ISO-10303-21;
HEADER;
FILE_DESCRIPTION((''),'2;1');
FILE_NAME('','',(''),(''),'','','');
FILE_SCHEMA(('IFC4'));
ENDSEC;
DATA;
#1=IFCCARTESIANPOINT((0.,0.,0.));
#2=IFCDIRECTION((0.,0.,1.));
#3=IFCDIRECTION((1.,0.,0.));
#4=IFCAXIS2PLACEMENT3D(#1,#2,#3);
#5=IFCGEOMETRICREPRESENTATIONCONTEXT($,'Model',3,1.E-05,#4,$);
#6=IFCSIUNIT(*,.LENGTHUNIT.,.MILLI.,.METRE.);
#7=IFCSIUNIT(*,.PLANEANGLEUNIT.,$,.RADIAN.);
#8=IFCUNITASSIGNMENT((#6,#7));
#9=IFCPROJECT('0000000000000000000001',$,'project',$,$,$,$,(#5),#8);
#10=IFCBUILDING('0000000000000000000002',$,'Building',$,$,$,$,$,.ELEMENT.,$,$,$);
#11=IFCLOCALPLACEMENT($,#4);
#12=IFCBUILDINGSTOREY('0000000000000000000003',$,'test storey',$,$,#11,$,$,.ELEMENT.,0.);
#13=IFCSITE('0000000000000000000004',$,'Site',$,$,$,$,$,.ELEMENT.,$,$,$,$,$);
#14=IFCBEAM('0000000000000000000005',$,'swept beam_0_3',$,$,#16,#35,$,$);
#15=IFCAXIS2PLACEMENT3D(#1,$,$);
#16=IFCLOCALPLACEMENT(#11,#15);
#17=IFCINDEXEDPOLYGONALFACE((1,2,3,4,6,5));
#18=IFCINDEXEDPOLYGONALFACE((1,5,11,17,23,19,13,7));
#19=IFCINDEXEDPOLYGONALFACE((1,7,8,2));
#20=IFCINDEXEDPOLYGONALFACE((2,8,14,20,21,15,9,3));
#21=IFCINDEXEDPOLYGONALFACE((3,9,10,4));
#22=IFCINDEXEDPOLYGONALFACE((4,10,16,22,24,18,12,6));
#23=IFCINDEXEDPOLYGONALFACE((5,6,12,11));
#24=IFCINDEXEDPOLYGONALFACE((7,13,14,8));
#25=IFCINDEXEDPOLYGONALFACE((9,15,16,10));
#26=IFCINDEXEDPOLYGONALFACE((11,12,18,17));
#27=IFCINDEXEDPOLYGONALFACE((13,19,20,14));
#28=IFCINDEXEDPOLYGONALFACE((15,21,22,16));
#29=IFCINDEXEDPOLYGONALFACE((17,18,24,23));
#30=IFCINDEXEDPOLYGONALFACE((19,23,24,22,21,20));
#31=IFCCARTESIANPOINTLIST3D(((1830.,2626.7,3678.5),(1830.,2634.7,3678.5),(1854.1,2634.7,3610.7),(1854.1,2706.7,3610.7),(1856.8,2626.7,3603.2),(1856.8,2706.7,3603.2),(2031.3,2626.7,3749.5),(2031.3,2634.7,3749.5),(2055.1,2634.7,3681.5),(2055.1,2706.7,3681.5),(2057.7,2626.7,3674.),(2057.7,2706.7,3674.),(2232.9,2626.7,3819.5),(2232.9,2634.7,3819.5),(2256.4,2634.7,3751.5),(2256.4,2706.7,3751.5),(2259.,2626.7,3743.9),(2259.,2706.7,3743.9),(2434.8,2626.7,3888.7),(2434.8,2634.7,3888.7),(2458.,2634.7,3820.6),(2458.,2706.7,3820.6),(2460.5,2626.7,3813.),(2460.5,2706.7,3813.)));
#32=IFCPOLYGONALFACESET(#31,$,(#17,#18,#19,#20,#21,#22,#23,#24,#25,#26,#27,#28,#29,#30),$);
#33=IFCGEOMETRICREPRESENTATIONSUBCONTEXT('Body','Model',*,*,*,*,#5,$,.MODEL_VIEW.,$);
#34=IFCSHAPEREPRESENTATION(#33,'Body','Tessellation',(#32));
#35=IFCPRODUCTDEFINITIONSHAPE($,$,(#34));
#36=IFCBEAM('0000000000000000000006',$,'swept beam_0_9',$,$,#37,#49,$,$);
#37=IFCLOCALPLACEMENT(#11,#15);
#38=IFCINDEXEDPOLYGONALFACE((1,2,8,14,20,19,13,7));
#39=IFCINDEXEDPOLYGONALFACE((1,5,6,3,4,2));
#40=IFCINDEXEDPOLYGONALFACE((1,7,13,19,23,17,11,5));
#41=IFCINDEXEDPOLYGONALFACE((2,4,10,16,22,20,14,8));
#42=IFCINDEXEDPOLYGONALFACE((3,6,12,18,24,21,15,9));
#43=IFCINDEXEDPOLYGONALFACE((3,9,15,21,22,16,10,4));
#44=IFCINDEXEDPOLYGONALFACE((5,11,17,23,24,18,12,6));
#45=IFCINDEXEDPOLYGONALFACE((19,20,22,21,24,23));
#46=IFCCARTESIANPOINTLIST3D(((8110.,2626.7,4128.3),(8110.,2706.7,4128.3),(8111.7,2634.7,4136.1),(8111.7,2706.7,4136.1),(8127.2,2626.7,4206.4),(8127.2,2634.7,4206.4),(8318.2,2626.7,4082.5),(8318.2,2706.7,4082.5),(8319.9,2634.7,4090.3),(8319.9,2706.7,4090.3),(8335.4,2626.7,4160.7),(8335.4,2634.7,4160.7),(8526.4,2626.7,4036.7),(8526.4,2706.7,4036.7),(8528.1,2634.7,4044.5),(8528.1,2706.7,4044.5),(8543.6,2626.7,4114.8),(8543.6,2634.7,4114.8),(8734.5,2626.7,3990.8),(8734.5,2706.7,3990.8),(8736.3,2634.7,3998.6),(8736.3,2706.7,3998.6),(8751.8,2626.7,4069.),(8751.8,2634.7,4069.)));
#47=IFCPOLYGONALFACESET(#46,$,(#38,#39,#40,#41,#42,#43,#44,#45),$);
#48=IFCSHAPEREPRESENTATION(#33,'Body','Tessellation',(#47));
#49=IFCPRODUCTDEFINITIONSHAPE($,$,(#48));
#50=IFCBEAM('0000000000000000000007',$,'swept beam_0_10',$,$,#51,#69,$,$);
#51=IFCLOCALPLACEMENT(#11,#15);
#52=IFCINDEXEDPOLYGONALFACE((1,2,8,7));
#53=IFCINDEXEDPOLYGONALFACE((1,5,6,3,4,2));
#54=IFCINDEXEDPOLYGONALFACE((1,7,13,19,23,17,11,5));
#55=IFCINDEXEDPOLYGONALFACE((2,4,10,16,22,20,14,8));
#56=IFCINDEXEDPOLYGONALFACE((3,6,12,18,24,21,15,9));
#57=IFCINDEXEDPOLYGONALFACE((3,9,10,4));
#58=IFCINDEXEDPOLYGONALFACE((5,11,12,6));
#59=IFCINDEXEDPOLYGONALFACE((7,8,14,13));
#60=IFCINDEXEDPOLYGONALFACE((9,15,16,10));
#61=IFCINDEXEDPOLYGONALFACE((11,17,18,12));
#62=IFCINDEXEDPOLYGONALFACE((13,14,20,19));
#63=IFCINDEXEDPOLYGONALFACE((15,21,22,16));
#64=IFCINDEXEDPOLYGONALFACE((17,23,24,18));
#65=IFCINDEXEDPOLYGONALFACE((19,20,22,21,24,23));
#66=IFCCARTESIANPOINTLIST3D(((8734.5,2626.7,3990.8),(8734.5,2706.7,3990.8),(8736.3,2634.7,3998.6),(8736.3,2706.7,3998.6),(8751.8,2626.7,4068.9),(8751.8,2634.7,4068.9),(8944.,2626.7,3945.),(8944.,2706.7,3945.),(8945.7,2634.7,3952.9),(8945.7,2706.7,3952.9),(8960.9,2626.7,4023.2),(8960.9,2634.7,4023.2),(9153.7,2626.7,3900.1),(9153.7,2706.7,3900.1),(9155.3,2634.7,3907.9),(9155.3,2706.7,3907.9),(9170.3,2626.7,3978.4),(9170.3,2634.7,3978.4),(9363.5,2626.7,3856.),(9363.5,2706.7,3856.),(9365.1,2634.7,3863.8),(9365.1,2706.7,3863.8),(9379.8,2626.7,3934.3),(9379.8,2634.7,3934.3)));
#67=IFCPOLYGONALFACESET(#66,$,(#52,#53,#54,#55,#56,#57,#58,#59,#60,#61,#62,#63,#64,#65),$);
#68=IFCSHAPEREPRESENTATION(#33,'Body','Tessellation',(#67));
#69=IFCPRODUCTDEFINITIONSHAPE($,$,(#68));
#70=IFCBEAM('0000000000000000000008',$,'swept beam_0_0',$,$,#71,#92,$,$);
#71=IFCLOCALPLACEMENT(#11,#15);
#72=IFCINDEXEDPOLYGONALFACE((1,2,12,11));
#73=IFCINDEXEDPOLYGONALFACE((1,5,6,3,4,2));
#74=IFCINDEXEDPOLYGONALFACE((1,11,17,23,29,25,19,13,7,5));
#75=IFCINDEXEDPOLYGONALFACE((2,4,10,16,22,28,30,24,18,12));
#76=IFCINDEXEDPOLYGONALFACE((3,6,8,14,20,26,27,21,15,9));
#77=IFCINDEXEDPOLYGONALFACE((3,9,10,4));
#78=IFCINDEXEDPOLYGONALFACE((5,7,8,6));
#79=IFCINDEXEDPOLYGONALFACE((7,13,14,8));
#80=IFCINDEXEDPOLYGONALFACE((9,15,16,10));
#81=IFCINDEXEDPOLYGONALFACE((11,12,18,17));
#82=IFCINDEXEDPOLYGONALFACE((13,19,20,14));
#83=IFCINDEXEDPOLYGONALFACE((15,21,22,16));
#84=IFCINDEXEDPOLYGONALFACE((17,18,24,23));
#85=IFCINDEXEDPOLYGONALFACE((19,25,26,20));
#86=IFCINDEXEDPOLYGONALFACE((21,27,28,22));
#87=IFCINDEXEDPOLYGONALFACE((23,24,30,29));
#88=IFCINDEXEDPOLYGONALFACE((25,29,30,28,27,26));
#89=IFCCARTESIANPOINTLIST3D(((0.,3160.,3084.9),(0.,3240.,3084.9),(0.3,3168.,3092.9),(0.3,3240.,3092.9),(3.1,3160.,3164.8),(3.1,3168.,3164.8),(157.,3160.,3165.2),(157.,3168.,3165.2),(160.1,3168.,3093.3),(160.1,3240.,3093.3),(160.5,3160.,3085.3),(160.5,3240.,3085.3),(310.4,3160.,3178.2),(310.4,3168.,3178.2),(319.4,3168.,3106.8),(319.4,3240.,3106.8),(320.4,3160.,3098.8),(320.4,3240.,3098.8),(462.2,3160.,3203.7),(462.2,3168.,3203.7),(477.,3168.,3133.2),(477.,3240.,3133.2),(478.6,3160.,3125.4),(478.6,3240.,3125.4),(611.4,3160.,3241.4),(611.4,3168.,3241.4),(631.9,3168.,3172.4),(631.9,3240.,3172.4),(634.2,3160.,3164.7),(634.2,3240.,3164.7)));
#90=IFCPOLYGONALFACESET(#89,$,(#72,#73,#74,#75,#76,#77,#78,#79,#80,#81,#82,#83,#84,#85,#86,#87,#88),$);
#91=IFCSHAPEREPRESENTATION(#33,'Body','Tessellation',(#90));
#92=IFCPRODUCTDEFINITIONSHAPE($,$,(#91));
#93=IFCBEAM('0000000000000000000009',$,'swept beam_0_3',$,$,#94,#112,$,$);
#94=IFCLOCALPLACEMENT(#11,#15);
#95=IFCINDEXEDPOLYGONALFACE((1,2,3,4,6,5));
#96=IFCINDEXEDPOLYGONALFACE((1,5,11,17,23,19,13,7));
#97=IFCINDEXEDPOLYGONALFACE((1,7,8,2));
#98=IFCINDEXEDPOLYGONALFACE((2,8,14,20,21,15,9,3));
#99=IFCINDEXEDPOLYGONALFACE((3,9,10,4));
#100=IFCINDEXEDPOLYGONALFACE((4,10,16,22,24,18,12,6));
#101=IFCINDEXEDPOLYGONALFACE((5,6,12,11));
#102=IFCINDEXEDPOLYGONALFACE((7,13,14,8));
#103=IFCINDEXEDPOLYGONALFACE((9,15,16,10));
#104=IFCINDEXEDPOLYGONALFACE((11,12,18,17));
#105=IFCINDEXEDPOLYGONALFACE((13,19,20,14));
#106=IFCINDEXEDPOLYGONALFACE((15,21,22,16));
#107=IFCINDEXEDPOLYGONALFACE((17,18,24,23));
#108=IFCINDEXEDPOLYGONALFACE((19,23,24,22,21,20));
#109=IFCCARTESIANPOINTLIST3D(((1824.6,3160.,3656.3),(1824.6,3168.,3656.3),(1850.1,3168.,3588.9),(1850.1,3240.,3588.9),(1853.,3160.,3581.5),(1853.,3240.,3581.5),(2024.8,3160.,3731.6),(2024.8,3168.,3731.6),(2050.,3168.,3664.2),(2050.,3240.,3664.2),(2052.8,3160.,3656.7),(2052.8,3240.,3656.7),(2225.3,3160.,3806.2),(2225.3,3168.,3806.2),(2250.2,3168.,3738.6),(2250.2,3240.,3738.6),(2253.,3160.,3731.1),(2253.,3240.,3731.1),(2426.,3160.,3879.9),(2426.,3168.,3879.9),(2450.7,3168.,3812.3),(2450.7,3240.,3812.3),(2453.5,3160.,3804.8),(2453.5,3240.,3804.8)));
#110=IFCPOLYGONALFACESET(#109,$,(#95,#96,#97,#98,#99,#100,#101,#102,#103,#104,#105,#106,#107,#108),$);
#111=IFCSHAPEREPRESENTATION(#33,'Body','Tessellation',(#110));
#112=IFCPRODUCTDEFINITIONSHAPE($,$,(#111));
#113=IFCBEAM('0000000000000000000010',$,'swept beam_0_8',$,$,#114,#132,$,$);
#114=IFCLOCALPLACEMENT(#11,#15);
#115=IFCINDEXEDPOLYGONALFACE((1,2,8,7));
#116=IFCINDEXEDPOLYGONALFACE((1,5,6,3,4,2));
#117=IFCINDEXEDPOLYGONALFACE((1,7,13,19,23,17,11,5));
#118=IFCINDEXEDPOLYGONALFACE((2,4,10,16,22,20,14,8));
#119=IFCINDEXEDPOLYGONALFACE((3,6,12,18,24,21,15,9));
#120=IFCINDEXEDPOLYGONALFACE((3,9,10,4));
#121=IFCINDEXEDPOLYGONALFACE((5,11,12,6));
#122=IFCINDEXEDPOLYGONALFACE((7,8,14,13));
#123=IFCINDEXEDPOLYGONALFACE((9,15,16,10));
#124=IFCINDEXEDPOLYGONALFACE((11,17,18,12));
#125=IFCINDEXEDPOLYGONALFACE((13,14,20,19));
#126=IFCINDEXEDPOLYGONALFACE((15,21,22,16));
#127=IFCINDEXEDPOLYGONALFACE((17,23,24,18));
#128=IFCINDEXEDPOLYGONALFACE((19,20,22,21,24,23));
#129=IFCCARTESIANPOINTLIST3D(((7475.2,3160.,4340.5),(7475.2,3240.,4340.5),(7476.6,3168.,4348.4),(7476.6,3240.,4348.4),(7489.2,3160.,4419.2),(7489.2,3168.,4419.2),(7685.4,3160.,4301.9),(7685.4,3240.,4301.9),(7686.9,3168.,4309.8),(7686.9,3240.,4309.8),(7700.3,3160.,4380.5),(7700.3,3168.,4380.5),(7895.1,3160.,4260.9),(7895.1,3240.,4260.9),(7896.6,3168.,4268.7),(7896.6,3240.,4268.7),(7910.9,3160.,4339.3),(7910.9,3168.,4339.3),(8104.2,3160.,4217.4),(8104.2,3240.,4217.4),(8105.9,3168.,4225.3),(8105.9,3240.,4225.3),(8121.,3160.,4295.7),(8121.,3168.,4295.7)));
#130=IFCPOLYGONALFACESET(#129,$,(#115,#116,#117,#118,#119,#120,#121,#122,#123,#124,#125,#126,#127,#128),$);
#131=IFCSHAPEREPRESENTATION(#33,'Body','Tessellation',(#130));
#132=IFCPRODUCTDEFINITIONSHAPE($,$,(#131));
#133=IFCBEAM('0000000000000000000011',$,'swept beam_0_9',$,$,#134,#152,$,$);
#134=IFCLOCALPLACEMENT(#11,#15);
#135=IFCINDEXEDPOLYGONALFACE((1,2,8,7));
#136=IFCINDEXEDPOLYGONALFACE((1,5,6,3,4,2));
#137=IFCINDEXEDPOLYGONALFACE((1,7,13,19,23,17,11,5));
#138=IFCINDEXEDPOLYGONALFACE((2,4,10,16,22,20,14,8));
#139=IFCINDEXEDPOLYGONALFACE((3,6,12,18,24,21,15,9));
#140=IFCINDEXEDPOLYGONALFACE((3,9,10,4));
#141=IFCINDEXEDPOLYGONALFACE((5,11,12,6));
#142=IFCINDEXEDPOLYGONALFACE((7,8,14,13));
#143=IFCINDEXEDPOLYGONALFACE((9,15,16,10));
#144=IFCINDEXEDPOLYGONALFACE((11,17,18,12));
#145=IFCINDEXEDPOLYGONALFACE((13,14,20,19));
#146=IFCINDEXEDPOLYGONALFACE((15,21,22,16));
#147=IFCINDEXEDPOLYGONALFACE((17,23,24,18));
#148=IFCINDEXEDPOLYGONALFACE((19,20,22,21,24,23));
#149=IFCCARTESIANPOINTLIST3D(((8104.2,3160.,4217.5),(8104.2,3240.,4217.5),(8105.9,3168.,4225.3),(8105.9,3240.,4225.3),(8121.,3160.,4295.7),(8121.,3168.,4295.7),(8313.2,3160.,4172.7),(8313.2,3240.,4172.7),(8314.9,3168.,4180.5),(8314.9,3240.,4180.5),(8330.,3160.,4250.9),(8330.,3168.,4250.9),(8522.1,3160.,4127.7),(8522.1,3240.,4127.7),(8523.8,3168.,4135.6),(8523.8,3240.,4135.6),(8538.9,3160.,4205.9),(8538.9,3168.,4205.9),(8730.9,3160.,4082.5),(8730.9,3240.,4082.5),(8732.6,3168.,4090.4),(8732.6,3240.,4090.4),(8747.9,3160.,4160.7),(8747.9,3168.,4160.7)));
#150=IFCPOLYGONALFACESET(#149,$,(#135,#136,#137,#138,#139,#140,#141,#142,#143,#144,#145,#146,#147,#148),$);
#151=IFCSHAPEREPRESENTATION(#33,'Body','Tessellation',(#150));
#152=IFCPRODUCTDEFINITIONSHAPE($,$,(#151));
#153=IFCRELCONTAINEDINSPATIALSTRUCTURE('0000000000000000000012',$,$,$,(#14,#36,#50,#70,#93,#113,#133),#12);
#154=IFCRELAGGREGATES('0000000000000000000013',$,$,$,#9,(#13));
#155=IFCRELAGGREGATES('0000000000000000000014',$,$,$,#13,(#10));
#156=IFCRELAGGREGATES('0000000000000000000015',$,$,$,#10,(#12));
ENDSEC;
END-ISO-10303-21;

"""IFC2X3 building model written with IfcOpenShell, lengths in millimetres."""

from ifc_helpers import new_model, entity, si_unit, origin_with_axes, place, context, subcontext, project, spatial, element, save


model = new_model("IFC2X3")

# Units and contexts
model_context = context("Model", 3, precision=1e-05, world=origin_with_axes())
body_context = subcontext(model_context, "Body", "Model", "MODEL_VIEW")
ifc_project = project(units=[si_unit("LENGTHUNIT", "METRE", prefix="MILLI"), si_unit("PLANEANGLEUNIT", "RADIAN")], contexts=[model_context])

# Site, building, storey
site = spatial("IfcSite", under=ifc_project, Name="Site", CompositionType="ELEMENT")
building = spatial("IfcBuilding", under=site, Name="Building", CompositionType="ELEMENT")
storey_placement = place(None, origin_with_axes())
storey = spatial("IfcBuildingStorey", under=building, at=storey_placement, Name="test storey", CompositionType="ELEMENT", Elevation=0.0)

# Beams
beam_1_placement = place(storey_placement, origin_with_axes())
element("IfcBeam", 1, at=beam_1_placement, inside=storey, Name="swept beam_0_3", context=body_context, shape_type="SweptSolid", body=[
    entity("IfcRevolvedAreaSolid", entity("IfcArbitraryClosedProfileDef", "AREA", None, entity("IfcPolyline", [entity("IfcCartesianPoint", [80.0, -40.0]), entity("IfcCartesianPoint", [80.0, -32.0]), entity("IfcCartesianPoint", [8.0, -32.0]), entity("IfcCartesianPoint", [8.0, 40.0]), entity("IfcCartesianPoint", [0.0, 40.0]), entity("IfcCartesianPoint", [0.0, -40.0]), entity("IfcCartesianPoint", [80.0, -40.0])])), entity("IfcAxis2Placement3D", entity("IfcCartesianPoint", [1856.8, 2666.7, 3603.2]), entity("IfcDirection", [-0.9424, 0.0, -0.3344]), entity("IfcDirection", [-0.3344, 0.0, 0.9424])), entity("IfcAxis1Placement", entity("IfcCartesianPoint", [-49301.6, 0.0, 0.0]), entity("IfcDirection", [0.0, 1.0, 0.0])), 0.012965),
])
beam_2_placement = place(storey_placement, origin_with_axes())
element("IfcBeam", 2, at=beam_2_placement, inside=storey, Name="swept beam_0_9", context=body_context, shape_type="SweptSolid", body=[
    entity("IfcRevolvedAreaSolid", entity("IfcArbitraryClosedProfileDef", "AREA", None, entity("IfcPolyline", [entity("IfcCartesianPoint", [80.0, -40.0]), entity("IfcCartesianPoint", [80.0, -32.0]), entity("IfcCartesianPoint", [8.0, -32.0]), entity("IfcCartesianPoint", [8.0, 40.0]), entity("IfcCartesianPoint", [0.0, 40.0]), entity("IfcCartesianPoint", [0.0, -40.0]), entity("IfcCartesianPoint", [80.0, -40.0])])), entity("IfcAxis2Placement3D", entity("IfcCartesianPoint", [8110.0, 2666.7, 4128.3]), entity("IfcDirection", [-0.9767, 0.0, 0.2144]), entity("IfcDirection", [0.2144, 0.0, 0.9767])), entity("IfcAxis1Placement", entity("IfcCartesianPoint", [-597124.1, 0.0, 0.0]), entity("IfcDirection", [0.0, 1.0, 0.0])), 0.001071),
])
beam_3_placement = place(storey_placement, origin_with_axes())
element("IfcBeam", 3, at=beam_3_placement, inside=storey, Name="swept beam_0_10", context=body_context, shape_type="SweptSolid", body=[
    entity("IfcRevolvedAreaSolid", entity("IfcArbitraryClosedProfileDef", "AREA", None, entity("IfcPolyline", [entity("IfcCartesianPoint", [-80.0, 40.0]), entity("IfcCartesianPoint", [-80.0, 32.0]), entity("IfcCartesianPoint", [-8.0, 32.0]), entity("IfcCartesianPoint", [-8.0, -40.0]), entity("IfcCartesianPoint", [0.0, -40.0]), entity("IfcCartesianPoint", [0.0, 40.0]), entity("IfcCartesianPoint", [-80.0, 40.0])])), entity("IfcAxis2Placement3D", entity("IfcCartesianPoint", [8734.5, 2666.7, 3990.8]), entity("IfcDirection", [-0.9765, 0.0, 0.2155]), entity("IfcDirection", [-0.2155, 0.0, -0.9765])), entity("IfcAxis1Placement", entity("IfcCartesianPoint", [-53161.2, 0.0, 0.0]), entity("IfcDirection", [0.0, 1.0, 0.0])), 0.0121),
])
beam_4_placement = place(storey_placement, origin_with_axes())
element("IfcBeam", 4, at=beam_4_placement, inside=storey, Name="swept beam_0_0", context=body_context, shape_type="SweptSolid", body=[
    entity("IfcRevolvedAreaSolid", entity("IfcArbitraryClosedProfileDef", "AREA", None, entity("IfcPolyline", [entity("IfcCartesianPoint", [-80.0, 40.0]), entity("IfcCartesianPoint", [-80.0, 32.0]), entity("IfcCartesianPoint", [-8.0, 32.0]), entity("IfcCartesianPoint", [-8.0, -40.0]), entity("IfcCartesianPoint", [0.0, -40.0]), entity("IfcCartesianPoint", [0.0, 40.0]), entity("IfcCartesianPoint", [-80.0, 40.0])])), entity("IfcAxis2Placement3D", entity("IfcCartesianPoint", [0.0, 3200.0, 3084.9]), entity("IfcDirection", [-0.9993, 0.0, 0.0382]), entity("IfcDirection", [-0.0382, 0.0, -0.9993])), entity("IfcAxis1Placement", entity("IfcCartesianPoint", [-1963.9, 0.0, 0.0]), entity("IfcDirection", [0.0, 1.0, 0.0])), 0.326914),
])
beam_5_placement = place(storey_placement, origin_with_axes())
element("IfcBeam", 5, at=beam_5_placement, inside=storey, Name="swept beam_0_3", context=body_context, shape_type="SweptSolid", body=[
    entity("IfcRevolvedAreaSolid", entity("IfcArbitraryClosedProfileDef", "AREA", None, entity("IfcPolyline", [entity("IfcCartesianPoint", [80.0, -40.0]), entity("IfcCartesianPoint", [80.0, -32.0]), entity("IfcCartesianPoint", [8.0, -32.0]), entity("IfcCartesianPoint", [8.0, 40.0]), entity("IfcCartesianPoint", [0.0, 40.0]), entity("IfcCartesianPoint", [0.0, -40.0]), entity("IfcCartesianPoint", [80.0, -40.0])])), entity("IfcAxis2Placement3D", entity("IfcCartesianPoint", [1853.0, 3200.0, 3581.5]), entity("IfcDirection", [-0.9352, 0.0, -0.3541]), entity("IfcDirection", [-0.3541, 0.0, 0.9352])), entity("IfcAxis1Placement", entity("IfcCartesianPoint", [-54056.0, 0.0, 0.0]), entity("IfcDirection", [0.0, 1.0, 0.0])), 0.011852),
])
beam_6_placement = place(storey_placement, origin_with_axes())
element("IfcBeam", 6, at=beam_6_placement, inside=storey, Name="swept beam_0_8", context=body_context, shape_type="SweptSolid", body=[
    entity("IfcRevolvedAreaSolid", entity("IfcArbitraryClosedProfileDef", "AREA", None, entity("IfcPolyline", [entity("IfcCartesianPoint", [80.0, -40.0]), entity("IfcCartesianPoint", [80.0, -32.0]), entity("IfcCartesianPoint", [8.0, -32.0]), entity("IfcCartesianPoint", [8.0, 40.0]), entity("IfcCartesianPoint", [0.0, 40.0]), entity("IfcCartesianPoint", [0.0, -40.0]), entity("IfcCartesianPoint", [80.0, -40.0])])), entity("IfcAxis2Placement3D", entity("IfcCartesianPoint", [7475.2, 3200.0, 4340.5]), entity("IfcDirection", [-0.9846, 0.0, 0.1749]), entity("IfcDirection", [0.1749, 0.0, 0.9846])), entity("IfcAxis1Placement", entity("IfcCartesianPoint", [-18444.5, 0.0, 0.0]), entity("IfcDirection", [0.0, 1.0, 0.0])), 0.034751),
])
beam_7_placement = place(storey_placement, origin_with_axes())
element("IfcBeam", 7, at=beam_7_placement, inside=storey, Name="swept beam_0_9", context=body_context, shape_type="SweptSolid", body=[
    entity("IfcRevolvedAreaSolid", entity("IfcArbitraryClosedProfileDef", "AREA", None, entity("IfcPolyline", [entity("IfcCartesianPoint", [80.0, -40.0]), entity("IfcCartesianPoint", [80.0, -32.0]), entity("IfcCartesianPoint", [8.0, -32.0]), entity("IfcCartesianPoint", [8.0, 40.0]), entity("IfcCartesianPoint", [0.0, 40.0]), entity("IfcCartesianPoint", [0.0, -40.0]), entity("IfcCartesianPoint", [80.0, -40.0])])), entity("IfcAxis2Placement3D", entity("IfcCartesianPoint", [8104.2, 3200.0, 4217.5]), entity("IfcDirection", [-0.9779, 0.0, 0.209]), entity("IfcDirection", [0.209, 0.0, 0.9779])), entity("IfcAxis1Placement", entity("IfcCartesianPoint", [-212965.9, 0.0, 0.0]), entity("IfcDirection", [0.0, 1.0, 0.0])), 0.00301),
])

save(model, "model.ifc")
